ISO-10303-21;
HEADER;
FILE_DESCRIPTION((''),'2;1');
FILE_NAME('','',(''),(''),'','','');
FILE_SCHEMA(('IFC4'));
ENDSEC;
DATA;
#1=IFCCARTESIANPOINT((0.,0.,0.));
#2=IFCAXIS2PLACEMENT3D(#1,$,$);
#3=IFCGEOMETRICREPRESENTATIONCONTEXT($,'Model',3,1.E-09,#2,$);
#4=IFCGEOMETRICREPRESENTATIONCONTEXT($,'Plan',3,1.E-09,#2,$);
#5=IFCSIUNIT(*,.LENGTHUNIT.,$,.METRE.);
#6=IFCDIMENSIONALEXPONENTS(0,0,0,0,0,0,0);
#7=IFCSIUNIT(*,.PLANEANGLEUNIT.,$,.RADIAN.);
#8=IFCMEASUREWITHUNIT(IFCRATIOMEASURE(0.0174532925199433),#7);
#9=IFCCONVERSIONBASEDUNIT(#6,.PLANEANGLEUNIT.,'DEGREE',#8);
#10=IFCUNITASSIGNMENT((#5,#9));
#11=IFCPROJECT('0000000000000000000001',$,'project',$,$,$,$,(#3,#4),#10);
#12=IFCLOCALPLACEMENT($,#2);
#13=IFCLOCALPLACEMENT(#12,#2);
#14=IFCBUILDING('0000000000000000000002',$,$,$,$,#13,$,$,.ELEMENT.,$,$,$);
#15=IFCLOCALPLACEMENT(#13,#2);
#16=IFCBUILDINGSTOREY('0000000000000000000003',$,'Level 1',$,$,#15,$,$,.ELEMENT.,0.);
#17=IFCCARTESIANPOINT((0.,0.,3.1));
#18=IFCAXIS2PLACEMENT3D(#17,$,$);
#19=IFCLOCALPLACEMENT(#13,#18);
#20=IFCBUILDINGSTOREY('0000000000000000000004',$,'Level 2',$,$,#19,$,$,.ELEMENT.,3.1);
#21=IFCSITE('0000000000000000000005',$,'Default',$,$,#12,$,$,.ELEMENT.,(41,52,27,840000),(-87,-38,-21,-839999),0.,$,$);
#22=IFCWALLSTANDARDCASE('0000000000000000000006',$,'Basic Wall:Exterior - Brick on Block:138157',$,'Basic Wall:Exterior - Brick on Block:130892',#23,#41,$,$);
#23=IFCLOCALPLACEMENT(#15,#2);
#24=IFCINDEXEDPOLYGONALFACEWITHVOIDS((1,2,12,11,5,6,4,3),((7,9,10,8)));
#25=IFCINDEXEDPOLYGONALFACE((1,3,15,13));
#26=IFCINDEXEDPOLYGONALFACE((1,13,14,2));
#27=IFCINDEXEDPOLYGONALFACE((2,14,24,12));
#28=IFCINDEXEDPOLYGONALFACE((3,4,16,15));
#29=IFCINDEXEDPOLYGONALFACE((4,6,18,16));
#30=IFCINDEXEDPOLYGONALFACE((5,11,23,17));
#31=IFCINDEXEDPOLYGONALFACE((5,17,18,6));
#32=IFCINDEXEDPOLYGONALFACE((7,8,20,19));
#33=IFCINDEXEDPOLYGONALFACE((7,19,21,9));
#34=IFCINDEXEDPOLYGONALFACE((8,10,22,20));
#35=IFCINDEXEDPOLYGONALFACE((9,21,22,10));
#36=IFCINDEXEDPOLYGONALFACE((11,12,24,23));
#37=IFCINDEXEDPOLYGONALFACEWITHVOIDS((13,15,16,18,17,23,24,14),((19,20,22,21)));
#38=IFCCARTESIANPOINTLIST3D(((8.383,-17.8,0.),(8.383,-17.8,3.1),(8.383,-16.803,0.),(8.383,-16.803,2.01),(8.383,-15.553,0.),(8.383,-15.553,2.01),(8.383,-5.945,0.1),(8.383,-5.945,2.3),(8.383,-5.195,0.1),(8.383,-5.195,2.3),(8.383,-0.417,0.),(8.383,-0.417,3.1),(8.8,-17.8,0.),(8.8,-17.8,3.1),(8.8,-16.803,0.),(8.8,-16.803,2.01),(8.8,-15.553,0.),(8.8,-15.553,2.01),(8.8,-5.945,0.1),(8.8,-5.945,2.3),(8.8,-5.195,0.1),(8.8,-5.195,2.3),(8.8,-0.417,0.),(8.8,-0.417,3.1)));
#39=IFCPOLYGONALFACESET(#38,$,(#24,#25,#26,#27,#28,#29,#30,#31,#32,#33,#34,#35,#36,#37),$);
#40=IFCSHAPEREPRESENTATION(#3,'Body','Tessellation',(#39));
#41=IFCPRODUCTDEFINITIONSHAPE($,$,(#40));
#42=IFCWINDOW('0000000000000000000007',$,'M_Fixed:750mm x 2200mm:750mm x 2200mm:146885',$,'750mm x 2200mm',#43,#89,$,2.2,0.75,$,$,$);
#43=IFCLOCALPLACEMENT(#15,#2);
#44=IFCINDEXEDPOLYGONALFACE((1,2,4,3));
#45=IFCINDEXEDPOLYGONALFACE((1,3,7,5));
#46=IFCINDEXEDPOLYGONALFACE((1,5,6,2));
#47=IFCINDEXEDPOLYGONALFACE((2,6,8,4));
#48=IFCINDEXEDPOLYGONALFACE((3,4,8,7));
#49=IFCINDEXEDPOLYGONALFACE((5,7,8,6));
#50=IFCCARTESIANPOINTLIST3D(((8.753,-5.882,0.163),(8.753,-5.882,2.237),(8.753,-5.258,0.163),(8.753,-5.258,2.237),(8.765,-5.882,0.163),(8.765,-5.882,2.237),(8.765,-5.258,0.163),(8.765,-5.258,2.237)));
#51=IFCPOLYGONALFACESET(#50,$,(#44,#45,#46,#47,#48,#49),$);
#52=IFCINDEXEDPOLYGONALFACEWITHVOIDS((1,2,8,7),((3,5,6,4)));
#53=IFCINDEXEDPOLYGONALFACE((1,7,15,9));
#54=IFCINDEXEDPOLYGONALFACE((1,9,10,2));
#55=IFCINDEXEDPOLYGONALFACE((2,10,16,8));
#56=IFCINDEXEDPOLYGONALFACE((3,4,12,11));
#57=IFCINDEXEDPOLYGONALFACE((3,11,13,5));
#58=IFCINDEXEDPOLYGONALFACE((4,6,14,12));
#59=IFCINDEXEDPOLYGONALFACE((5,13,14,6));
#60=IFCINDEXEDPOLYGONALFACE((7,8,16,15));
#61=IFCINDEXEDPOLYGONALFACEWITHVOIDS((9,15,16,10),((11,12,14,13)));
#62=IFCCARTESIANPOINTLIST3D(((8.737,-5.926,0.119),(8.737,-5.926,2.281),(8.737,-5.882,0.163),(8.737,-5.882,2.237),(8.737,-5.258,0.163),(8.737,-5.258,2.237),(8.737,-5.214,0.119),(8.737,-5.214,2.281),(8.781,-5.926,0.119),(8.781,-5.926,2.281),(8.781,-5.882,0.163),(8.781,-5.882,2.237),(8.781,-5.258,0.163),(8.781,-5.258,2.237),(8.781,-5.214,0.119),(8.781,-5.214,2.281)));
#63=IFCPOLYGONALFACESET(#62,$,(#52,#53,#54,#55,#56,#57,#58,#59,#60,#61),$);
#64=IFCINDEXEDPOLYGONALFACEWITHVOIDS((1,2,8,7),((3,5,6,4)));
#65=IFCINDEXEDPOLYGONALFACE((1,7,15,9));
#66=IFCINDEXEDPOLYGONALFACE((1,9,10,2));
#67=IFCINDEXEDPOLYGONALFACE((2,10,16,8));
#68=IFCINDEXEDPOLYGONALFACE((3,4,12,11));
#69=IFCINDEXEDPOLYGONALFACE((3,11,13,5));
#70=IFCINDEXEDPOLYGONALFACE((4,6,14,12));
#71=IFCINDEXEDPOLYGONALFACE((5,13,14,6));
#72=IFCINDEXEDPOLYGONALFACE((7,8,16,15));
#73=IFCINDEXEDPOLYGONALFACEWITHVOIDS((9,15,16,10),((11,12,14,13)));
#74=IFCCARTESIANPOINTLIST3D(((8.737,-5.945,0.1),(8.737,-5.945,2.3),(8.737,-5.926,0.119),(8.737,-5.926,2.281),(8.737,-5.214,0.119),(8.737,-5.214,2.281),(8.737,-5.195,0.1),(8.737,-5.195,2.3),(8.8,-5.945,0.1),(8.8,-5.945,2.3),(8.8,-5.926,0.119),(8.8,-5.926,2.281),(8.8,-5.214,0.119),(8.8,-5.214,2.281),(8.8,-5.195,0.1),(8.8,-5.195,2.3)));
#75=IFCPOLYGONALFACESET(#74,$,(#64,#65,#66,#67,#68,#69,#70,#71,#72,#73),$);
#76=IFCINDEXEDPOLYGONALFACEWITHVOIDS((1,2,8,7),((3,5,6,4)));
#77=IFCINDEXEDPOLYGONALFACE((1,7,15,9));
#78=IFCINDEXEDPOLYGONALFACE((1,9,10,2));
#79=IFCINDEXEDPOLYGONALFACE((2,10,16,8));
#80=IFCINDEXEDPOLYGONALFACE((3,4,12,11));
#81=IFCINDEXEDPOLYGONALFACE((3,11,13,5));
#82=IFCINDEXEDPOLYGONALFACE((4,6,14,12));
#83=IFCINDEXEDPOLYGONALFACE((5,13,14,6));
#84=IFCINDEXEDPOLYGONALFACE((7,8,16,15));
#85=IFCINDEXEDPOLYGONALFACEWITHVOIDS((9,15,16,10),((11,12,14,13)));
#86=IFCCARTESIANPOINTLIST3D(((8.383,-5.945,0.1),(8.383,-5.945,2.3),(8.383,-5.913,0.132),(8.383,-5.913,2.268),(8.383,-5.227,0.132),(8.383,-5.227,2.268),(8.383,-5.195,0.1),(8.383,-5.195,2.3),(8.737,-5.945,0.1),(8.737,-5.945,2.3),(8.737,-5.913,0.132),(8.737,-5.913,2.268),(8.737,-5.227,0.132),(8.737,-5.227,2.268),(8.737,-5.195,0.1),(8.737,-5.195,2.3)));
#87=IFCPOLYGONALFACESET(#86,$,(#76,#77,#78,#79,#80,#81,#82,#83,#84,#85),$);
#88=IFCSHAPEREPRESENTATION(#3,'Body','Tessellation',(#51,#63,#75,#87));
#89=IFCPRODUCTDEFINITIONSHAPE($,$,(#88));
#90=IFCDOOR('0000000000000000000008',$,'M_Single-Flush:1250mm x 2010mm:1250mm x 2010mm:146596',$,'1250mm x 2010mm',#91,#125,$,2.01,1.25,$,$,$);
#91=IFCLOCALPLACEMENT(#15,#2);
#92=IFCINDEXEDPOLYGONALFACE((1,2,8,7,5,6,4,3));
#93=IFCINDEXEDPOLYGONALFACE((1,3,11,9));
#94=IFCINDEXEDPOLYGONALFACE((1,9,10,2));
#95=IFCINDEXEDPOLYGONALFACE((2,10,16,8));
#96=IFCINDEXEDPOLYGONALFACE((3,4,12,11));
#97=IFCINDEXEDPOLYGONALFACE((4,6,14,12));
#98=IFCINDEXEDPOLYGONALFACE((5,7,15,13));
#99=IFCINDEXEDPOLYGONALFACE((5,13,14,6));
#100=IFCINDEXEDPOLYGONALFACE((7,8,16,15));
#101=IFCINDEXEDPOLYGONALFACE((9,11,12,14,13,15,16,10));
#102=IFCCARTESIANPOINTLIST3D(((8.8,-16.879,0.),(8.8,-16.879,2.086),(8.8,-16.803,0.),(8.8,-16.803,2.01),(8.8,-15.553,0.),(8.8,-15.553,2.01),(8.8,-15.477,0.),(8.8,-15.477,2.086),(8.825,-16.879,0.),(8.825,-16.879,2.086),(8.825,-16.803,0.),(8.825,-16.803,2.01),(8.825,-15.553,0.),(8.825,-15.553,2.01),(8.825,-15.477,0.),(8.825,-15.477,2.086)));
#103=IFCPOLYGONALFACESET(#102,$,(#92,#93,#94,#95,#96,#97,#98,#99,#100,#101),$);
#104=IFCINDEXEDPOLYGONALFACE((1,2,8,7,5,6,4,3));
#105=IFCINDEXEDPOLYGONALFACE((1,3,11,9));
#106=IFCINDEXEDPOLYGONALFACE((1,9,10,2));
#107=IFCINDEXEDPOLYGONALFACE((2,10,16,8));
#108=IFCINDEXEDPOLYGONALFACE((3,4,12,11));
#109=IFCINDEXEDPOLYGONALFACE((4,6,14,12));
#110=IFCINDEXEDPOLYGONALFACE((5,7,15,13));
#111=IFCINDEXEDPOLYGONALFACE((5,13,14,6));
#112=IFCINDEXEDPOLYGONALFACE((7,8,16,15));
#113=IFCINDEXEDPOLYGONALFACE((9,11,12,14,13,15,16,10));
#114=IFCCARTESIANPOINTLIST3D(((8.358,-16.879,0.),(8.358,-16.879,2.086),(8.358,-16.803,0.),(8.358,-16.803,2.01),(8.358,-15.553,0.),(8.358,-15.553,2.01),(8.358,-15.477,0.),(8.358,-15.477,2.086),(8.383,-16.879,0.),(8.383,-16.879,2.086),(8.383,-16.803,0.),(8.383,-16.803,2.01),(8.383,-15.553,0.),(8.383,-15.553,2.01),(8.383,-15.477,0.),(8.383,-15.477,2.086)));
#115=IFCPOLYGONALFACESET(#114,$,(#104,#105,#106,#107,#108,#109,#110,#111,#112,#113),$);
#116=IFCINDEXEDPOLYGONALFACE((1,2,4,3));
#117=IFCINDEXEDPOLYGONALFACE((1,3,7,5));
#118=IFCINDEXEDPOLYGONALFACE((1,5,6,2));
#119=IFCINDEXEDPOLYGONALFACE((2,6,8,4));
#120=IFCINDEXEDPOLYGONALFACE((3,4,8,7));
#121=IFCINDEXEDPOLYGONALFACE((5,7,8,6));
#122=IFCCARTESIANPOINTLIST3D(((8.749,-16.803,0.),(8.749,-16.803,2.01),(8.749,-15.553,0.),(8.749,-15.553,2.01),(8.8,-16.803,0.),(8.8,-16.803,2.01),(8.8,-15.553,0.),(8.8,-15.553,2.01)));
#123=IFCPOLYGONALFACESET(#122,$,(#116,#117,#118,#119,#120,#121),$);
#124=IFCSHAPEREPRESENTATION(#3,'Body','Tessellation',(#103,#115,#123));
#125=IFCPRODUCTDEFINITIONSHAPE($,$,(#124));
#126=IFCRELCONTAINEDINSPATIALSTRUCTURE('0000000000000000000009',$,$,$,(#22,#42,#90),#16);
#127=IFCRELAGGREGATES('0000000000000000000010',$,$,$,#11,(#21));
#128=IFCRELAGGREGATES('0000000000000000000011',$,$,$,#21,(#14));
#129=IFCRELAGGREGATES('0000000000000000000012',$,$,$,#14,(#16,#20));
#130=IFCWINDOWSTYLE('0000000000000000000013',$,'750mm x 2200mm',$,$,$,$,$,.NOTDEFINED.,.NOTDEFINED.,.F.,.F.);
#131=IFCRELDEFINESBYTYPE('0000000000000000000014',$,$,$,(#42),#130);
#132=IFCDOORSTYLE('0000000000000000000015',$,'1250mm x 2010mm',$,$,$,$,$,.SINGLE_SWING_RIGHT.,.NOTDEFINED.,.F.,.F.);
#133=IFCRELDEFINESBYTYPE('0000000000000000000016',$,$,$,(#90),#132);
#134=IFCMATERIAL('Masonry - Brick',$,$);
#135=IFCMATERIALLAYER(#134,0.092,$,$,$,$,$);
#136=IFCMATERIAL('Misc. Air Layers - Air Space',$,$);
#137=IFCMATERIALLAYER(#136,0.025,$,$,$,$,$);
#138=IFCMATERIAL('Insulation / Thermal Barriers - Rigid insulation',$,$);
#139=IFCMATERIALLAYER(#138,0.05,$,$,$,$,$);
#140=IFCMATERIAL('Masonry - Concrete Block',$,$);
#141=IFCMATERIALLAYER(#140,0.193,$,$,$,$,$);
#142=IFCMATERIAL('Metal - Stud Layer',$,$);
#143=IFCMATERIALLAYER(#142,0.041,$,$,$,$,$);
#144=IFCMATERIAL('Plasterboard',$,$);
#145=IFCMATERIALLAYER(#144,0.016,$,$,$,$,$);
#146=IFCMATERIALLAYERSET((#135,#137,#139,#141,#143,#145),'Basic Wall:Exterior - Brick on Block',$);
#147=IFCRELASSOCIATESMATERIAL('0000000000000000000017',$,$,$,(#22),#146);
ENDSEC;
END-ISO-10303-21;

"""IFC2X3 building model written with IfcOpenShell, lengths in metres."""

from ifc_helpers import new_model, entity, si_unit, converted_unit, frame, frame_2d, origin, origin_2d_with_axis, place, context, project, spatial, polyline, rectangle, outline, extrude, source, transform, mapped, material, layer, layer_set, layer_usage, type_object, type_shapes, element, fill, save


model = new_model("IFC2X3")

# Units and contexts
model_context = context("Model", 3, precision=1e-09, world=origin())
plan_context = context("Plan", 3, precision=1e-09, world=origin())
ifc_project = project(units=[si_unit("LENGTHUNIT", "METRE"), converted_unit("PLANEANGLEUNIT", "DEGREE", entity("IfcRatioMeasure", 0.0174532925199433), si_unit("PLANEANGLEUNIT", "RADIAN"), dimensions=[0, 0, 0, 0, 0, 0, 0])], contexts=[model_context, plan_context])

# Site, building, storey
site_placement = place(None, origin())
site = spatial("IfcSite", under=ifc_project, at=site_placement, Name="Default", CompositionType="ELEMENT", RefLatitude=(41, 52, 27, 840000), RefLongitude=(-87, -38, -21, -839999), RefElevation=0.0)
building_placement = place(site_placement, origin())
building = spatial("IfcBuilding", under=site, at=building_placement, CompositionType="ELEMENT")
storey_1_placement = place(building_placement, origin())
storey_1 = spatial("IfcBuildingStorey", under=building, at=storey_1_placement, Name="Level 1", CompositionType="ELEMENT", Elevation=0.0)

# Wall, openings, window, door
ifc_material_1 = material(Name="Masonry - Brick")
ifc_layer_1 = layer(ifc_material_1, 0.092)
ifc_material_2 = material(Name="Misc. Air Layers - Air Space")
ifc_layer_2 = layer(ifc_material_2, 0.025)
ifc_material_3 = material(Name="Insulation / Thermal Barriers - Rigid insulation")
ifc_layer_3 = layer(ifc_material_3, 0.05)
ifc_material_4 = material(Name="Masonry - Concrete Block")
ifc_layer_4 = layer(ifc_material_4, 0.193)
ifc_material_5 = material(Name="Metal - Stud Layer")
ifc_layer_5 = layer(ifc_material_5, 0.041)
ifc_material_6 = material(Name="Plasterboard")
ifc_layer_6 = layer(ifc_material_6, 0.016)
ifc_layer_set_1 = layer_set([ifc_layer_1, ifc_layer_2, ifc_layer_3, ifc_layer_4, ifc_layer_5, ifc_layer_6], Name="Basic Wall:Exterior - Brick on Block")
ifc_layer_usage_1 = layer_usage(ifc_layer_set_1, "AXIS2", "NEGATIVE", 0.2085)
wall_1_placement = place(storey_1_placement, frame((8.5915, -0.417, 0.0), z_axis=(0.0, 0.0, 1.0), x_axis=(0.0, -1.0, 0.0)))
wall_1 = element("IfcWallStandardCase", 1, at=wall_1_placement, inside=storey_1, material=ifc_layer_usage_1, Name="Basic Wall:Exterior - Brick on Block:138157", ObjectType="Basic Wall:Exterior - Brick on Block:130892", context=model_context, shape_type="SweptSolid", body=[
    extrude(rectangle(XDim=17.383, YDim=0.417, at=frame_2d((8.6915, 0.0), x_axis=(-1.0, 0.0))), origin(), (0.0, 0.0, 1.0), 3.1),
])
opening_1_placement = place(wall_1_placement, frame((15.136, -0.2085, 0.0)))
opening_1 = element("IfcOpeningElement", 2, at=opening_1_placement, cuts=wall_1, ObjectType="Opening", context=model_context, shape_type="SweptSolid", body=[
    extrude(rectangle(XDim=1.25, YDim=2.01, at=frame_2d((1.005, 0.625), x_axis=(0.0, 1.0))), frame((0.0, 0.0, 0.0), z_axis=(0.0, 1.0, 0.0), x_axis=(0.0, 0.0, 1.0)), (0.0, 0.0, 1.0), 0.417),
])
opening_2_placement = place(wall_1_placement, frame((4.778, -0.2085, 0.1)))
opening_2 = element("IfcOpeningElement", 3, at=opening_2_placement, cuts=wall_1, ObjectType="Opening", context=model_context, shape_type="SweptSolid", body=[
    extrude(rectangle(XDim=2.2, YDim=0.75, at=frame_2d((1.1, 0.375), x_axis=(1.0, 0.0))), frame((0.0, 0.0, 0.0), z_axis=(0.0, 1.0, 0.0), x_axis=(0.0, 0.0, 1.0)), (0.0, 0.0, 1.0), 0.417),
])
window_style_1 = type_object("IfcWindowStyle", Name="750mm x 2200mm", ConstructionType="NOTDEFINED", OperationType="NOTDEFINED", ParameterTakesPrecedence=False, Sizeable=False)
shared_shape_1 = source(origin(), model_context, "Body", "SweptSolid", [
    extrude(rectangle(XDim=0.012, YDim=0.624, at=origin_2d_with_axis()), frame((0.375, 0.376, 0.063), z_axis=(0.0, 0.0, 1.0), x_axis=(0.0, -1.0, 0.0)), (0.0, 0.0, 1.0), 2.074),
    extrude(outline(polyline([(-0.356, -1.081), (0.356, -1.081), (0.356, 1.081), (-0.356, 1.081), (-0.356, -1.081)]), holes=[polyline([(-0.312, -1.037), (-0.312, 1.037), (0.312, 1.037), (0.312, -1.037), (-0.312, -1.037)])]), frame((0.375, 0.354, 1.1), z_axis=(0.0, 1.0, 0.0), x_axis=(1.0, 0.0, 0.0)), (0.0, 0.0, 1.0), 0.044),
    extrude(outline(polyline([(-0.375, -1.1), (0.375, -1.1), (0.375, 1.1), (-0.375, 1.1), (-0.375, -1.1)]), holes=[polyline([(-0.356, -1.081), (-0.356, 1.081), (0.356, 1.081), (0.356, -1.081), (-0.356, -1.081)])]), frame((0.375, 0.354, 1.1), z_axis=(0.0, 1.0, 0.0), x_axis=(1.0, 0.0, 0.0)), (0.0, 0.0, 1.0), 0.063),
    extrude(outline(polyline([(-0.375, -1.1), (0.375, -1.1), (0.375, 1.1), (-0.375, 1.1), (-0.375, -1.1)]), holes=[polyline([(-0.343, -1.068), (-0.343, 1.068), (0.343, 1.068), (0.343, -1.068), (-0.343, -1.068)])]), frame((0.375, 0.0, 1.1), z_axis=(0.0, 1.0, 0.0), x_axis=(1.0, 0.0, 0.0)), (0.0, 0.0, 1.0), 0.354),
])
type_shapes(window_style_1, [shared_shape_1])
window_1_placement = place(opening_2_placement, origin())
window_1 = element("IfcWindow", 4, at=window_1_placement, inside=storey_1, type_object=window_style_1, Name="M_Fixed:750mm x 2200mm:750mm x 2200mm:146885", ObjectType="750mm x 2200mm", OverallHeight=2.2, OverallWidth=0.75, context=model_context, shape_type="MappedRepresentation", body=[
    mapped(shared_shape_1, transform((0.0, 0.0, 0.0), scale=1.0)),
])
fill(opening_2, window_1)
door_style_1 = type_object("IfcDoorStyle", Name="1250mm x 2010mm", ConstructionType="NOTDEFINED", OperationType="SINGLE_SWING_RIGHT", ParameterTakesPrecedence=False, Sizeable=False)
shared_shape_2 = source(origin(), model_context, "Body", "SweptSolid", [
    extrude(outline(polyline([(-0.701, -1.062), (0.701, -1.062), (0.701, 1.024), (0.625, 1.024), (0.625, -0.986), (-0.625, -0.986), (-0.625, 1.024), (-0.701, 1.024), (-0.701, -1.062)])), frame((0.625, 0.417, 1.024), z_axis=(0.0, 1.0, 0.0), x_axis=(1.0, 0.0, 0.0)), (0.0, 0.0, 1.0), 0.025),
    extrude(outline(polyline([(-1.062, -0.701), (1.024, -0.701), (1.024, -0.625), (-0.986, -0.625), (-0.986, 0.625), (1.024, 0.625), (1.024, 0.701), (-1.062, 0.701), (-1.062, -0.701)])), frame((0.625, -0.025, 1.024), z_axis=(0.0, 1.0, 0.0), x_axis=(0.0, 0.0, -1.0)), (0.0, 0.0, 1.0), 0.025),
    extrude(rectangle(XDim=0.051, YDim=1.25, at=origin_2d_with_axis()), frame((0.625, 0.3915, 0.0), z_axis=(0.0, 0.0, 1.0), x_axis=(0.0, 1.0, 0.0)), (0.0, 0.0, 1.0), 2.01),
])
type_shapes(door_style_1, [shared_shape_2])
door_1_placement = place(opening_1_placement, origin())
door_1 = element("IfcDoor", 5, at=door_1_placement, inside=storey_1, type_object=door_style_1, Name="M_Single-Flush:1250mm x 2010mm:1250mm x 2010mm:146596", ObjectType="1250mm x 2010mm", OverallHeight=2.01, OverallWidth=1.25, context=model_context, shape_type="MappedRepresentation", body=[
    mapped(shared_shape_2, transform((0.0, 0.0, 0.0), scale=1.0)),
])
fill(opening_1, door_1)

# Shared definitions
storey_2_placement = place(building_placement, frame((0.0, 0.0, 3.1)))
storey_2 = spatial("IfcBuildingStorey", under=building, at=storey_2_placement, Name="Level 2", CompositionType="ELEMENT", Elevation=3.1)

save(model, "model.ifc")
